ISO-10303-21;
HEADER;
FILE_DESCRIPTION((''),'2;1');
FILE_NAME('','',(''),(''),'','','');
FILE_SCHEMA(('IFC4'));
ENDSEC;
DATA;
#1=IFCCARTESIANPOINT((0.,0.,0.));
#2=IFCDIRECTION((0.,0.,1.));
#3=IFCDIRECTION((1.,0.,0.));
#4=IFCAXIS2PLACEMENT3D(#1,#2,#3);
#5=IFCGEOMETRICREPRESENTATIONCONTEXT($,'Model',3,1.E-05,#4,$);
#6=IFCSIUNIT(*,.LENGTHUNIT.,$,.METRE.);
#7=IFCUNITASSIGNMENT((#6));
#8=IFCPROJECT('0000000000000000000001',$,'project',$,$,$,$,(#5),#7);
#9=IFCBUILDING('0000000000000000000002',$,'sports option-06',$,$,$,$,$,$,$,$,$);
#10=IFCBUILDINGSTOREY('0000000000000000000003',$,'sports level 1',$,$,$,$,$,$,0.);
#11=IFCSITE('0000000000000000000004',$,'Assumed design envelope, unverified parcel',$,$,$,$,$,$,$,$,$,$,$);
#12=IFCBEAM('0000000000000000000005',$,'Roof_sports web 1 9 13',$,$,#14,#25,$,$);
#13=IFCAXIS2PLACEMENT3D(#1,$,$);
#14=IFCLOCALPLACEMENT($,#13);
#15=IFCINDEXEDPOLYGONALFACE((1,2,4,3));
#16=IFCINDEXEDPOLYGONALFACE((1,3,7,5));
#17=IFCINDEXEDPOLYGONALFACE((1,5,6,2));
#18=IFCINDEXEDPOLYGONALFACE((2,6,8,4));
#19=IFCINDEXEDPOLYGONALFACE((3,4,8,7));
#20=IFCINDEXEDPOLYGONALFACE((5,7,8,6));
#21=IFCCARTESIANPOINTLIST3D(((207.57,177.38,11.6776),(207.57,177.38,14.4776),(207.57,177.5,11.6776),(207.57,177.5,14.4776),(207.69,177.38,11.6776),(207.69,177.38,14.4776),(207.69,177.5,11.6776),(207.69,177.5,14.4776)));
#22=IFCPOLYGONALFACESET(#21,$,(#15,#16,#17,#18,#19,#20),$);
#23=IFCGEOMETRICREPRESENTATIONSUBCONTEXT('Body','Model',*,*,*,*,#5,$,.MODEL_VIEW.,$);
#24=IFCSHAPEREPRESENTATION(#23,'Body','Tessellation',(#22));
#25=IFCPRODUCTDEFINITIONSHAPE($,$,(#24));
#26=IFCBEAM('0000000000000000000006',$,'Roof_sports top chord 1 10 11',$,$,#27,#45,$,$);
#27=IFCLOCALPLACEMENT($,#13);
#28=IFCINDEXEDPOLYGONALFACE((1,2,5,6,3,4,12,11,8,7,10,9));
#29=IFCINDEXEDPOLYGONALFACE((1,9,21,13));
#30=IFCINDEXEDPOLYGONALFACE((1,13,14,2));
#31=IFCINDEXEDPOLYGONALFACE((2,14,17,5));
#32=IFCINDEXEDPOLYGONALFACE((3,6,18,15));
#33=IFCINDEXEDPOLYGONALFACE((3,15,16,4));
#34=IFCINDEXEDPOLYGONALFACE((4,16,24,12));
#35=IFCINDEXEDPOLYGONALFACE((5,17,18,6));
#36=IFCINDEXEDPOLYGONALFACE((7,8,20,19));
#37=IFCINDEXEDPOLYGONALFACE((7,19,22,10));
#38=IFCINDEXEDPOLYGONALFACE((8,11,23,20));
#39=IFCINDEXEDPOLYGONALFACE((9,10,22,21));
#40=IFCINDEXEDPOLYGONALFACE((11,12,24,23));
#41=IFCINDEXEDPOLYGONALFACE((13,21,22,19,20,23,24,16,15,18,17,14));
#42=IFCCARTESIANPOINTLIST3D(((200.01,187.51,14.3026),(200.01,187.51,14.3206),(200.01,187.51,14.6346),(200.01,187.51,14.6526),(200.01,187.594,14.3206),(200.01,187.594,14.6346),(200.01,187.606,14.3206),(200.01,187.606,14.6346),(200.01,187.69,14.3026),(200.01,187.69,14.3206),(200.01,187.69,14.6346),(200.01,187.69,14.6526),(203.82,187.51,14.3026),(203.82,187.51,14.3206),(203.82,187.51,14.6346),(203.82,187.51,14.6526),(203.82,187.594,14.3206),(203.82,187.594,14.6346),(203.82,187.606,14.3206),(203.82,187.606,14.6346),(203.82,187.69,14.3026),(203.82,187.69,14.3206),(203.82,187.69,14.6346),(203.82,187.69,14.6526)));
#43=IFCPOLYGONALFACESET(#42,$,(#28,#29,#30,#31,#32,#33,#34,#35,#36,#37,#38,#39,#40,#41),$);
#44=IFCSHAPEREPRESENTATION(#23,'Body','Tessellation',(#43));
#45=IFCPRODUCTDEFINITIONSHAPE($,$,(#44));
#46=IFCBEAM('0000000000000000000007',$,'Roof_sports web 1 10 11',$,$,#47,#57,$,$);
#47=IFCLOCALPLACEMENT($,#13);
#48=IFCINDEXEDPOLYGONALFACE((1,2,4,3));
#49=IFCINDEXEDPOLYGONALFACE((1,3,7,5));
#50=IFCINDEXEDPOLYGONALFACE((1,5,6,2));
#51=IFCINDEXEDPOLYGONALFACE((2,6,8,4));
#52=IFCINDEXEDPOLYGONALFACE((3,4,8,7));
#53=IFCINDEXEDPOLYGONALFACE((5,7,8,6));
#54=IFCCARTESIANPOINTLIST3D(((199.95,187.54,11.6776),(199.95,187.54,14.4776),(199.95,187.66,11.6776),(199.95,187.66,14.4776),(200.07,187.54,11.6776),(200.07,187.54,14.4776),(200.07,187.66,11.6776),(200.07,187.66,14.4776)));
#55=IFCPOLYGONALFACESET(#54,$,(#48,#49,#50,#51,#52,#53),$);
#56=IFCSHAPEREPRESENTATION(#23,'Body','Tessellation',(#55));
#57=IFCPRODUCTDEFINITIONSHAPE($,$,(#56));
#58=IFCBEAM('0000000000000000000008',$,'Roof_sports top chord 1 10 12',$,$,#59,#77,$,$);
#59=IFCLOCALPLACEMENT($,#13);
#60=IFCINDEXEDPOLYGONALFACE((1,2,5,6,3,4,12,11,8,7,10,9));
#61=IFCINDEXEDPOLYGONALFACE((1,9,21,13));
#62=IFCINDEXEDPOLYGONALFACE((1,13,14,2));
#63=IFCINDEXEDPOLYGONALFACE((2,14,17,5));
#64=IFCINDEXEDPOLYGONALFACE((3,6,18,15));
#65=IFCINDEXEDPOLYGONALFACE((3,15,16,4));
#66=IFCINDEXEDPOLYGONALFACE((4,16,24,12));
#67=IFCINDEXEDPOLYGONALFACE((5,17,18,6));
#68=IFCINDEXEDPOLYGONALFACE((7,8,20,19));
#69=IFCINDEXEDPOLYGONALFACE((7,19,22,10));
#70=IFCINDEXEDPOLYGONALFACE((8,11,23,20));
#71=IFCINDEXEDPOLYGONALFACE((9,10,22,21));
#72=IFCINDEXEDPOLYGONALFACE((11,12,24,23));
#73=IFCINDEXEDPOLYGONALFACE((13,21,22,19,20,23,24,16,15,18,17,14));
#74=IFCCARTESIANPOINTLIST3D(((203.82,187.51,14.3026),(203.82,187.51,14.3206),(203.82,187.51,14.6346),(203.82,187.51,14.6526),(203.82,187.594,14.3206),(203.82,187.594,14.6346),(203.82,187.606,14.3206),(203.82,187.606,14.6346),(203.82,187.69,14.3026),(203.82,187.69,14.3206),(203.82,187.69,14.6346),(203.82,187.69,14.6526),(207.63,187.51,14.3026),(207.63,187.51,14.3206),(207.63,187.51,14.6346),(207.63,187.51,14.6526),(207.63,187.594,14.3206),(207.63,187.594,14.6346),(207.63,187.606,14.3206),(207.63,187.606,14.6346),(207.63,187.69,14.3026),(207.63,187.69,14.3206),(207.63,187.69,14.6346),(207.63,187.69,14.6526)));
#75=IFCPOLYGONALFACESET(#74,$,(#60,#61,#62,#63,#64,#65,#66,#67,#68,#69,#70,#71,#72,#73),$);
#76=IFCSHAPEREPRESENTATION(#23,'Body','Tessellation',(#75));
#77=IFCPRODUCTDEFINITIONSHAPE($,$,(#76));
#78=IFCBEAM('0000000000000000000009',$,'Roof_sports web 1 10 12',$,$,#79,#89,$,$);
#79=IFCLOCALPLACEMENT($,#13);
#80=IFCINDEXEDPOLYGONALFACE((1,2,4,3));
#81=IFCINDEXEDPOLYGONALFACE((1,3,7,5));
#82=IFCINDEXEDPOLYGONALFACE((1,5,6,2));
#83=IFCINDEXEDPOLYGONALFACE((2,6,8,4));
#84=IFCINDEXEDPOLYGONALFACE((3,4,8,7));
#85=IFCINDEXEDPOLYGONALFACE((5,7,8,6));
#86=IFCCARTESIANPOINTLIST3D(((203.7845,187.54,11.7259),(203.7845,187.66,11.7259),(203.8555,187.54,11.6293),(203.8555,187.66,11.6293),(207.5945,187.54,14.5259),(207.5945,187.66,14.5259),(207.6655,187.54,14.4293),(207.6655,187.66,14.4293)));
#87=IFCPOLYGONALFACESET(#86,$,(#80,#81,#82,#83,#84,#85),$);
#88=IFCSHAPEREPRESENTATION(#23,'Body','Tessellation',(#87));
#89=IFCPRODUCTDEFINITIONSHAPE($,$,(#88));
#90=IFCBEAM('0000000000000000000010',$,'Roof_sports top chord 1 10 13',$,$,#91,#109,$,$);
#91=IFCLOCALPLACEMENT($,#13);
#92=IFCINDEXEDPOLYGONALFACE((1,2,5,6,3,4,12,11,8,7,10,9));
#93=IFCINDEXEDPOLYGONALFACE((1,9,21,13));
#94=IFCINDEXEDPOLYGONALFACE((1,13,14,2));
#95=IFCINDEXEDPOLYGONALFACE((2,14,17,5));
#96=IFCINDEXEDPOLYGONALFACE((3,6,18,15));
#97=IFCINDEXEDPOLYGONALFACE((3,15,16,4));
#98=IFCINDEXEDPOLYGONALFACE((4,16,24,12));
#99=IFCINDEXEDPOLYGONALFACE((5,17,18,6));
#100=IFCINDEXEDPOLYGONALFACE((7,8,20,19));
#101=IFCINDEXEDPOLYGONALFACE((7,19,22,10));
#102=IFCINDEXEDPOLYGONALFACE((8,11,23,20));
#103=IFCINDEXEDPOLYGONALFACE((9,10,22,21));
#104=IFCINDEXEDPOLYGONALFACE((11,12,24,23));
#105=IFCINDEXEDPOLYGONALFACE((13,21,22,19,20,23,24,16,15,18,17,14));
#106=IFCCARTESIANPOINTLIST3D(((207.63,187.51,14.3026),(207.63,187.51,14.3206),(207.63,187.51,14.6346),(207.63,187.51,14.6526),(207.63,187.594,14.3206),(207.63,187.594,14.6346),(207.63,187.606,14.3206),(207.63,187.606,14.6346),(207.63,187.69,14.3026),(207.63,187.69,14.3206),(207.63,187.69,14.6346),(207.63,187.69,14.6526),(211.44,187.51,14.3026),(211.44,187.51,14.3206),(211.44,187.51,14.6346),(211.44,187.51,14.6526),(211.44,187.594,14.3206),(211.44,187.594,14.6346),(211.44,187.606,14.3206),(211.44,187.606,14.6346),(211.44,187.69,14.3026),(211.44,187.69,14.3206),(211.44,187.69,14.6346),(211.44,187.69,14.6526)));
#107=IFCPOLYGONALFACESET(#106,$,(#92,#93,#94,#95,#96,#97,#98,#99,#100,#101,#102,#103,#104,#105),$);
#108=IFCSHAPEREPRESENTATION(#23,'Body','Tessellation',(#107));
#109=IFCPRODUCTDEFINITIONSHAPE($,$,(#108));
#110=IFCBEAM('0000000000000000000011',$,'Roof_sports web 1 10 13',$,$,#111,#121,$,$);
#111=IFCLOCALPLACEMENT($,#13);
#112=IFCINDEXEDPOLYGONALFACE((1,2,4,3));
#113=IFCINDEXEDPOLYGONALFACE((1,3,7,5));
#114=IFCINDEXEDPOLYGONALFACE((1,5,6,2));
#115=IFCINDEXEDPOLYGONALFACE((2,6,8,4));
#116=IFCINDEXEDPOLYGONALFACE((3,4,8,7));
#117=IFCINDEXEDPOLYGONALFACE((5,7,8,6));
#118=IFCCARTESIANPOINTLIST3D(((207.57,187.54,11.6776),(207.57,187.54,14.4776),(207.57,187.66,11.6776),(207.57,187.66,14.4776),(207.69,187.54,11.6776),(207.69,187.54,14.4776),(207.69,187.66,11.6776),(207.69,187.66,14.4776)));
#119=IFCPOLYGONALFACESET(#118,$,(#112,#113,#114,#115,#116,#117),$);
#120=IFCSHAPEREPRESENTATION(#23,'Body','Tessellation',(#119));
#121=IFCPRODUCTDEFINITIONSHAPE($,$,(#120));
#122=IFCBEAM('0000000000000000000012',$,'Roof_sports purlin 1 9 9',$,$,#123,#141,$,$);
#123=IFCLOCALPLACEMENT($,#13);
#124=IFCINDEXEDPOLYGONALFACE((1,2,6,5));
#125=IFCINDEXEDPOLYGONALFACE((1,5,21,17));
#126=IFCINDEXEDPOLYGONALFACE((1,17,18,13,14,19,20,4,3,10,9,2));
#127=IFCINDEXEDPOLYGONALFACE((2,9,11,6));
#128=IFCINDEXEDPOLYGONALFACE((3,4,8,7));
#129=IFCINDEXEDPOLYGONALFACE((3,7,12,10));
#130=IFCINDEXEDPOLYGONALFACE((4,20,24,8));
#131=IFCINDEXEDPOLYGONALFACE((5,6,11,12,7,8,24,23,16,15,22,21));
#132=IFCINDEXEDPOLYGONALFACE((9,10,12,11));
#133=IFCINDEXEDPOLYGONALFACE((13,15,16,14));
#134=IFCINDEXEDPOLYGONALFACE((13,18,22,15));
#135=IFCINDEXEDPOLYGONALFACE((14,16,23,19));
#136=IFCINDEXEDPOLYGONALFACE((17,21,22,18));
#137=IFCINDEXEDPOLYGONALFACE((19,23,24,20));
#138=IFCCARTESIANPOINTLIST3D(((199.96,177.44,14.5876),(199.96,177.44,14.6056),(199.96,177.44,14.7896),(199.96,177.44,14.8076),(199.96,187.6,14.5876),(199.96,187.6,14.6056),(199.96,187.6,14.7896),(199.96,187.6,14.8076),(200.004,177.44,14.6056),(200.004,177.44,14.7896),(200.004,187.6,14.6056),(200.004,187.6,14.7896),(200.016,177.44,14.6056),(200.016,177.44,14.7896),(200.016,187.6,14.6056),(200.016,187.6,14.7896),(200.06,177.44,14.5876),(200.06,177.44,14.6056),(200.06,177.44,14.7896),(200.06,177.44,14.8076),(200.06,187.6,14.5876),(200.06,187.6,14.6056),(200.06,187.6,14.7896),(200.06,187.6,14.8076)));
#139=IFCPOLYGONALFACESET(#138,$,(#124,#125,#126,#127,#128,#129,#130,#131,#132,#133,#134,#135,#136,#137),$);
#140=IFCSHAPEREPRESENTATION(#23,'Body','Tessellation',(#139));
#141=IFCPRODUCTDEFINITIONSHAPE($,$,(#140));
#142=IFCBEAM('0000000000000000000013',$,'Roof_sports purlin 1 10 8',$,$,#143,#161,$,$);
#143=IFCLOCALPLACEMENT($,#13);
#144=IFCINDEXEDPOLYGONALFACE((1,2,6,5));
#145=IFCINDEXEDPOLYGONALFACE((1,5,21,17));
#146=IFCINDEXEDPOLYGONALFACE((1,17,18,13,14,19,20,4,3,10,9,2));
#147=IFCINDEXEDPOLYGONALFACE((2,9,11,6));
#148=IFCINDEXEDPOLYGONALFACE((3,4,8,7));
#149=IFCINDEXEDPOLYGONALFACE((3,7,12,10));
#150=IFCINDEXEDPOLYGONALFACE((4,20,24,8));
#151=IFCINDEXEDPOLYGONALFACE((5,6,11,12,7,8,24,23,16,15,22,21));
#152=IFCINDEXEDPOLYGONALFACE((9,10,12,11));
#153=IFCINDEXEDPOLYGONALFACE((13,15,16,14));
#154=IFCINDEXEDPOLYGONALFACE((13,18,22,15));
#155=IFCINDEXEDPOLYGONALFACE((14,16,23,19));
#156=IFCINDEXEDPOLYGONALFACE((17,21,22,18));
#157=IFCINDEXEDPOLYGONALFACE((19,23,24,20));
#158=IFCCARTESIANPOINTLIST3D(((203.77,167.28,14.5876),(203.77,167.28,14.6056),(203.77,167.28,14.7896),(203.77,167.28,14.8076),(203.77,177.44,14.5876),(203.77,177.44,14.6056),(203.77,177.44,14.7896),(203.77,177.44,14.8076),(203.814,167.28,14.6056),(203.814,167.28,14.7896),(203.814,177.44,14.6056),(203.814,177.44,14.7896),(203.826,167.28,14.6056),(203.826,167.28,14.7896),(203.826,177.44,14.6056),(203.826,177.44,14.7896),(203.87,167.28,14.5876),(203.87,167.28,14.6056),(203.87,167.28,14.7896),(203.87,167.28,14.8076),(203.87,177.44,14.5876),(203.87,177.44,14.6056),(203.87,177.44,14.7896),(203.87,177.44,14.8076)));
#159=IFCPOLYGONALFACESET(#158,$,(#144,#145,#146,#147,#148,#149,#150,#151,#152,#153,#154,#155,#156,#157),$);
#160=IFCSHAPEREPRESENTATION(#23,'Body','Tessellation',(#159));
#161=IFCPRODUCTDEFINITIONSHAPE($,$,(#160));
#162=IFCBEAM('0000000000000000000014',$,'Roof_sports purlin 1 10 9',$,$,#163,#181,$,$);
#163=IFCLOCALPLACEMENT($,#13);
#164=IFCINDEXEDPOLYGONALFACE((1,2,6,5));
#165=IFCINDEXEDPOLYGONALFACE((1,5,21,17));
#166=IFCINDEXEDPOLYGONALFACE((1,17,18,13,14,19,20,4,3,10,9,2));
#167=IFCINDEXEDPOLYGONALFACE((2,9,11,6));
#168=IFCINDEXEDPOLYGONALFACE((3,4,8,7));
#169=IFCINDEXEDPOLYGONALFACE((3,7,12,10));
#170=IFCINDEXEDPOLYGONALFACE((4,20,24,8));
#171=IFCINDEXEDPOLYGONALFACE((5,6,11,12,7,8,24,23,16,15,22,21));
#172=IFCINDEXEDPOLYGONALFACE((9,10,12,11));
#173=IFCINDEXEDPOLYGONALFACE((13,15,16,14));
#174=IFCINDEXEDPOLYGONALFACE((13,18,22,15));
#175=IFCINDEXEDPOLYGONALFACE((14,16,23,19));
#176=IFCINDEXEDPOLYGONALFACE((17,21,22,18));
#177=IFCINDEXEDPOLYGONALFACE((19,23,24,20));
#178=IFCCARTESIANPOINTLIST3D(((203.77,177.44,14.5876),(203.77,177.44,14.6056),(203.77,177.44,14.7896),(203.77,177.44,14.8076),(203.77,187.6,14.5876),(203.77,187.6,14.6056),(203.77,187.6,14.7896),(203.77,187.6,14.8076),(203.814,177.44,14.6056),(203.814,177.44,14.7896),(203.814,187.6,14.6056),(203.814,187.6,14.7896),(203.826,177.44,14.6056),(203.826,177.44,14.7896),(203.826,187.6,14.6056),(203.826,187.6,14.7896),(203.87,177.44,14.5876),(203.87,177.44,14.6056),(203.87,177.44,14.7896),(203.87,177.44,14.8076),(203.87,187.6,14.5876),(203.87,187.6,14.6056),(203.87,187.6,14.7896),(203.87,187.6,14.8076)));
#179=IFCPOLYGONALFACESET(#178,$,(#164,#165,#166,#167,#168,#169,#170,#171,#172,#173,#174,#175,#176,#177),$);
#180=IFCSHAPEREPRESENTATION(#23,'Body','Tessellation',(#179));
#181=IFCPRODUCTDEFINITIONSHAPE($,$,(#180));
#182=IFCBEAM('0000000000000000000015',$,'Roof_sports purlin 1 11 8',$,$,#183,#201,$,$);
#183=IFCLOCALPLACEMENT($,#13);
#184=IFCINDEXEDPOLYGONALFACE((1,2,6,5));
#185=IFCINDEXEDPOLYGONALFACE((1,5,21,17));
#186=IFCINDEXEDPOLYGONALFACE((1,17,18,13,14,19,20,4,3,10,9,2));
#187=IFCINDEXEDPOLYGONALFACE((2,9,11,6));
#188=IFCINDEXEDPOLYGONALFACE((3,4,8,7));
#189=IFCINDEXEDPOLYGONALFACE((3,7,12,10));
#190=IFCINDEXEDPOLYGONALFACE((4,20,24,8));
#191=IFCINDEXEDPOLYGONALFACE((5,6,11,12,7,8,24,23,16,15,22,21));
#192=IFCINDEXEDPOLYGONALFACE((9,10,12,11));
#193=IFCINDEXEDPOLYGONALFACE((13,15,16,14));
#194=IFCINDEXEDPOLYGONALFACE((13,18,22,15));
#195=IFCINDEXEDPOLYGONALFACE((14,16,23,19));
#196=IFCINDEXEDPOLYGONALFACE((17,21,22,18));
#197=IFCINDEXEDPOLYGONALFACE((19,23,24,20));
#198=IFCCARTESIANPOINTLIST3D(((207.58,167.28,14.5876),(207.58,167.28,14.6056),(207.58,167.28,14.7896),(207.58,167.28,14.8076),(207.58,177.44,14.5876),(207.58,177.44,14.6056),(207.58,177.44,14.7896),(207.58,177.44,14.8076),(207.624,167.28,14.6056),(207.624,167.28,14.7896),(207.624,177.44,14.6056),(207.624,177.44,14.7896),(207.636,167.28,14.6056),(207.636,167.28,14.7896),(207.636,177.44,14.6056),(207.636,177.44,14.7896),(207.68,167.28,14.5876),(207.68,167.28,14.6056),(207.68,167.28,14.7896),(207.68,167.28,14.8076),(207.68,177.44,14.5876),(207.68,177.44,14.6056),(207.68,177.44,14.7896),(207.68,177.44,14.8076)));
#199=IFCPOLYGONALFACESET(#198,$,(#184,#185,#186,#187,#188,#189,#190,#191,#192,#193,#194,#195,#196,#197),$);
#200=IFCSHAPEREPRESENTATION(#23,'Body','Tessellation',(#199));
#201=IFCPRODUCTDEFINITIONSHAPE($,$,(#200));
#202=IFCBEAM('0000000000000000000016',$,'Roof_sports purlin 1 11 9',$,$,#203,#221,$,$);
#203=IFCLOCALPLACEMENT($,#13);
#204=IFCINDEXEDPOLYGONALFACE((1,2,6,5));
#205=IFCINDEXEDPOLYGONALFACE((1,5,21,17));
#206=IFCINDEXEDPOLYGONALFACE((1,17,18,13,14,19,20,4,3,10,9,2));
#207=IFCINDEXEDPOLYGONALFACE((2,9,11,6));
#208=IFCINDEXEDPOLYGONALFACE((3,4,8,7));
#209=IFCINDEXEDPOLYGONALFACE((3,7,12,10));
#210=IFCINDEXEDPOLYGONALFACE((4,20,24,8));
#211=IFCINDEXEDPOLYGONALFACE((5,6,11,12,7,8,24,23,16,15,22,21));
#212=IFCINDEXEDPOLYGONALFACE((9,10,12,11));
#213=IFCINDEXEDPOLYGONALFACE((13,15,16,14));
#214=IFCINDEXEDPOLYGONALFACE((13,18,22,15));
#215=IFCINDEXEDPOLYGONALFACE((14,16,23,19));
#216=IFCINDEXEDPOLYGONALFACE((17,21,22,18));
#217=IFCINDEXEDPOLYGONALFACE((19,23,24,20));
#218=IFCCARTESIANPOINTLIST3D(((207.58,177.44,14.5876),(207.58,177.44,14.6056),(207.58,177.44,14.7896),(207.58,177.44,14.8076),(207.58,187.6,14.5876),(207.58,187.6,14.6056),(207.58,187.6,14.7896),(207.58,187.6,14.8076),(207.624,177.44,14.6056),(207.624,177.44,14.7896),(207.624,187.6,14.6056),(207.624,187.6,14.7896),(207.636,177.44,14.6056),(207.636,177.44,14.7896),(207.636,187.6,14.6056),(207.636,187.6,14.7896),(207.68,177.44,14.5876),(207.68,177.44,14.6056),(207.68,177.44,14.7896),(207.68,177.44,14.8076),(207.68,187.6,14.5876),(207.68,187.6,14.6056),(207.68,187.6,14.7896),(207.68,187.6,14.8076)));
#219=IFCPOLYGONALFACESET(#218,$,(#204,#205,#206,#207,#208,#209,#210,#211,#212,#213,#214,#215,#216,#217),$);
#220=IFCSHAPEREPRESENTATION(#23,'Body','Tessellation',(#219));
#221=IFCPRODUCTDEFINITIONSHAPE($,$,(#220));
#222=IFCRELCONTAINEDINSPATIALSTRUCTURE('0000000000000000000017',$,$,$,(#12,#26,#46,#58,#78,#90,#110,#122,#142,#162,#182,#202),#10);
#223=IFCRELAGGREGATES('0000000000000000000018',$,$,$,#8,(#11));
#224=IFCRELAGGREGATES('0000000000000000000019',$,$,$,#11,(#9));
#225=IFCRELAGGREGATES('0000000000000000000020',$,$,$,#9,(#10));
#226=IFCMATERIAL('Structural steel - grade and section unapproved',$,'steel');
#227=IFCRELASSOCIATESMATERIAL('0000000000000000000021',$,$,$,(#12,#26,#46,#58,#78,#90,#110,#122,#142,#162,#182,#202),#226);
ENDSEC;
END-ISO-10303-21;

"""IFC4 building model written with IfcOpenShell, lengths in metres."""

from ifc_helpers import new_model, si_unit, frame, origin_with_axes, place, context, subcontext, project, spatial, rectangle, i_section, extrude, material, element, save


model = new_model("IFC4")

# Units and contexts
model_context = context("Model", 3, precision=1e-05, world=origin_with_axes())
body_context = subcontext(model_context, "Body", "Model", "MODEL_VIEW")
ifc_project = project(units=[si_unit("LENGTHUNIT", "METRE")], contexts=[model_context])

# Site, building, storey
site = spatial("IfcSite", under=ifc_project, Name="Assumed design envelope, unverified parcel")
building = spatial("IfcBuilding", under=site, Name="sports option-06")
storey = spatial("IfcBuildingStorey", under=building, Name="sports level 1", Elevation=0.0)

# Shared definitions
ifc_material_1 = material(Name="Structural steel - grade and section unapproved", Category="steel")

# Beams
beam_1_placement = place(None, frame((207.63, 177.44, 11.6776), z_axis=(0.0, 0.0, 1.0), x_axis=(-1.0, 0.0, 0.0)))
element("IfcBeam", 1, at=beam_1_placement, inside=storey, material=ifc_material_1, Name="Roof_sports web 1 9 13", context=body_context, shape_type="SweptSolid", body=[
    extrude(rectangle(XDim=0.12, YDim=0.12), origin_with_axes(), (0.0, 0.0, 1.0), 2.8),
])
beam_2_placement = place(None, frame((200.01, 187.6, 14.4776), z_axis=(1.0, 0.0, 0.0), x_axis=(0.0, 1.0, 0.0)))
element("IfcBeam", 2, at=beam_2_placement, inside=storey, material=ifc_material_1, Name="Roof_sports top chord 1 10 11", context=body_context, shape_type="SweptSolid", body=[
    extrude(i_section(OverallWidth=0.18, OverallDepth=0.35, WebThickness=0.012, FlangeThickness=0.018, FilletRadius=0.0), origin_with_axes(), (0.0, 0.0, 1.0), 3.81),
])
beam_3_placement = place(None, frame((200.01, 187.6, 11.6776), z_axis=(0.0, 0.0, 1.0), x_axis=(-1.0, 0.0, 0.0)))
element("IfcBeam", 3, at=beam_3_placement, inside=storey, material=ifc_material_1, Name="Roof_sports web 1 10 11", context=body_context, shape_type="SweptSolid", body=[
    extrude(rectangle(XDim=0.12, YDim=0.12), origin_with_axes(), (0.0, 0.0, 1.0), 2.8),
])
beam_4_placement = place(None, frame((203.82, 187.6, 14.4776), z_axis=(1.0, 0.0, 0.0), x_axis=(0.0, 1.0, 0.0)))
element("IfcBeam", 4, at=beam_4_placement, inside=storey, material=ifc_material_1, Name="Roof_sports top chord 1 10 12", context=body_context, shape_type="SweptSolid", body=[
    extrude(i_section(OverallWidth=0.18, OverallDepth=0.35, WebThickness=0.012, FlangeThickness=0.018, FilletRadius=0.0), origin_with_axes(), (0.0, 0.0, 1.0), 3.81),
])
beam_5_placement = place(None, frame((203.82, 187.6, 11.6776), z_axis=(0.805799, 0.0, 0.592189), x_axis=(0.0, 1.0, 0.0)))
element("IfcBeam", 5, at=beam_5_placement, inside=storey, material=ifc_material_1, Name="Roof_sports web 1 10 12", context=body_context, shape_type="SweptSolid", body=[
    extrude(rectangle(XDim=0.12, YDim=0.12), origin_with_axes(), (0.0, 0.0, 1.0), 4.7282),
])
beam_6_placement = place(None, frame((207.63, 187.6, 14.4776), z_axis=(1.0, 0.0, 0.0), x_axis=(0.0, 1.0, 0.0)))
element("IfcBeam", 6, at=beam_6_placement, inside=storey, material=ifc_material_1, Name="Roof_sports top chord 1 10 13", context=body_context, shape_type="SweptSolid", body=[
    extrude(i_section(OverallWidth=0.18, OverallDepth=0.35, WebThickness=0.012, FlangeThickness=0.018, FilletRadius=0.0), origin_with_axes(), (0.0, 0.0, 1.0), 3.81),
])
beam_7_placement = place(None, frame((207.63, 187.6, 11.6776), z_axis=(0.0, 0.0, 1.0), x_axis=(-1.0, 0.0, 0.0)))
element("IfcBeam", 7, at=beam_7_placement, inside=storey, material=ifc_material_1, Name="Roof_sports web 1 10 13", context=body_context, shape_type="SweptSolid", body=[
    extrude(rectangle(XDim=0.12, YDim=0.12), origin_with_axes(), (0.0, 0.0, 1.0), 2.8),
])
for number, where, z_axis, x_axis, name in (
    (8, (200.01, 177.44, 14.6976), (0.0, 1.0, 0.0), (-1.0, 0.0, 0.0), "Roof_sports purlin 1 9 9"),
    (9, (203.82, 167.28, 14.6976), (0.0, 1.0, 0.0), (-1.0, 0.0, 0.0), "Roof_sports purlin 1 10 8"),
    (10, (203.82, 177.44, 14.6976), (0.0, 1.0, 0.0), (-1.0, 0.0, 0.0), "Roof_sports purlin 1 10 9"),
    (11, (207.63, 167.28, 14.6976), (0.0, 1.0, 0.0), (-1.0, 0.0, 0.0), "Roof_sports purlin 1 11 8"),
    (12, (207.63, 177.44, 14.6976), (0.0, 1.0, 0.0), (-1.0, 0.0, 0.0), "Roof_sports purlin 1 11 9"),
):
    element("IfcBeam", number, at=place(None, frame(where, z_axis=z_axis, x_axis=x_axis)), inside=storey, material=ifc_material_1, Name=name, context=body_context, shape_type="SweptSolid", body=[
        extrude(i_section(OverallWidth=0.1, OverallDepth=0.22, WebThickness=0.012, FlangeThickness=0.018, FilletRadius=0.0), origin_with_axes(), (0.0, 0.0, 1.0), 10.16),
    ])

save(model, "model.ifc")
